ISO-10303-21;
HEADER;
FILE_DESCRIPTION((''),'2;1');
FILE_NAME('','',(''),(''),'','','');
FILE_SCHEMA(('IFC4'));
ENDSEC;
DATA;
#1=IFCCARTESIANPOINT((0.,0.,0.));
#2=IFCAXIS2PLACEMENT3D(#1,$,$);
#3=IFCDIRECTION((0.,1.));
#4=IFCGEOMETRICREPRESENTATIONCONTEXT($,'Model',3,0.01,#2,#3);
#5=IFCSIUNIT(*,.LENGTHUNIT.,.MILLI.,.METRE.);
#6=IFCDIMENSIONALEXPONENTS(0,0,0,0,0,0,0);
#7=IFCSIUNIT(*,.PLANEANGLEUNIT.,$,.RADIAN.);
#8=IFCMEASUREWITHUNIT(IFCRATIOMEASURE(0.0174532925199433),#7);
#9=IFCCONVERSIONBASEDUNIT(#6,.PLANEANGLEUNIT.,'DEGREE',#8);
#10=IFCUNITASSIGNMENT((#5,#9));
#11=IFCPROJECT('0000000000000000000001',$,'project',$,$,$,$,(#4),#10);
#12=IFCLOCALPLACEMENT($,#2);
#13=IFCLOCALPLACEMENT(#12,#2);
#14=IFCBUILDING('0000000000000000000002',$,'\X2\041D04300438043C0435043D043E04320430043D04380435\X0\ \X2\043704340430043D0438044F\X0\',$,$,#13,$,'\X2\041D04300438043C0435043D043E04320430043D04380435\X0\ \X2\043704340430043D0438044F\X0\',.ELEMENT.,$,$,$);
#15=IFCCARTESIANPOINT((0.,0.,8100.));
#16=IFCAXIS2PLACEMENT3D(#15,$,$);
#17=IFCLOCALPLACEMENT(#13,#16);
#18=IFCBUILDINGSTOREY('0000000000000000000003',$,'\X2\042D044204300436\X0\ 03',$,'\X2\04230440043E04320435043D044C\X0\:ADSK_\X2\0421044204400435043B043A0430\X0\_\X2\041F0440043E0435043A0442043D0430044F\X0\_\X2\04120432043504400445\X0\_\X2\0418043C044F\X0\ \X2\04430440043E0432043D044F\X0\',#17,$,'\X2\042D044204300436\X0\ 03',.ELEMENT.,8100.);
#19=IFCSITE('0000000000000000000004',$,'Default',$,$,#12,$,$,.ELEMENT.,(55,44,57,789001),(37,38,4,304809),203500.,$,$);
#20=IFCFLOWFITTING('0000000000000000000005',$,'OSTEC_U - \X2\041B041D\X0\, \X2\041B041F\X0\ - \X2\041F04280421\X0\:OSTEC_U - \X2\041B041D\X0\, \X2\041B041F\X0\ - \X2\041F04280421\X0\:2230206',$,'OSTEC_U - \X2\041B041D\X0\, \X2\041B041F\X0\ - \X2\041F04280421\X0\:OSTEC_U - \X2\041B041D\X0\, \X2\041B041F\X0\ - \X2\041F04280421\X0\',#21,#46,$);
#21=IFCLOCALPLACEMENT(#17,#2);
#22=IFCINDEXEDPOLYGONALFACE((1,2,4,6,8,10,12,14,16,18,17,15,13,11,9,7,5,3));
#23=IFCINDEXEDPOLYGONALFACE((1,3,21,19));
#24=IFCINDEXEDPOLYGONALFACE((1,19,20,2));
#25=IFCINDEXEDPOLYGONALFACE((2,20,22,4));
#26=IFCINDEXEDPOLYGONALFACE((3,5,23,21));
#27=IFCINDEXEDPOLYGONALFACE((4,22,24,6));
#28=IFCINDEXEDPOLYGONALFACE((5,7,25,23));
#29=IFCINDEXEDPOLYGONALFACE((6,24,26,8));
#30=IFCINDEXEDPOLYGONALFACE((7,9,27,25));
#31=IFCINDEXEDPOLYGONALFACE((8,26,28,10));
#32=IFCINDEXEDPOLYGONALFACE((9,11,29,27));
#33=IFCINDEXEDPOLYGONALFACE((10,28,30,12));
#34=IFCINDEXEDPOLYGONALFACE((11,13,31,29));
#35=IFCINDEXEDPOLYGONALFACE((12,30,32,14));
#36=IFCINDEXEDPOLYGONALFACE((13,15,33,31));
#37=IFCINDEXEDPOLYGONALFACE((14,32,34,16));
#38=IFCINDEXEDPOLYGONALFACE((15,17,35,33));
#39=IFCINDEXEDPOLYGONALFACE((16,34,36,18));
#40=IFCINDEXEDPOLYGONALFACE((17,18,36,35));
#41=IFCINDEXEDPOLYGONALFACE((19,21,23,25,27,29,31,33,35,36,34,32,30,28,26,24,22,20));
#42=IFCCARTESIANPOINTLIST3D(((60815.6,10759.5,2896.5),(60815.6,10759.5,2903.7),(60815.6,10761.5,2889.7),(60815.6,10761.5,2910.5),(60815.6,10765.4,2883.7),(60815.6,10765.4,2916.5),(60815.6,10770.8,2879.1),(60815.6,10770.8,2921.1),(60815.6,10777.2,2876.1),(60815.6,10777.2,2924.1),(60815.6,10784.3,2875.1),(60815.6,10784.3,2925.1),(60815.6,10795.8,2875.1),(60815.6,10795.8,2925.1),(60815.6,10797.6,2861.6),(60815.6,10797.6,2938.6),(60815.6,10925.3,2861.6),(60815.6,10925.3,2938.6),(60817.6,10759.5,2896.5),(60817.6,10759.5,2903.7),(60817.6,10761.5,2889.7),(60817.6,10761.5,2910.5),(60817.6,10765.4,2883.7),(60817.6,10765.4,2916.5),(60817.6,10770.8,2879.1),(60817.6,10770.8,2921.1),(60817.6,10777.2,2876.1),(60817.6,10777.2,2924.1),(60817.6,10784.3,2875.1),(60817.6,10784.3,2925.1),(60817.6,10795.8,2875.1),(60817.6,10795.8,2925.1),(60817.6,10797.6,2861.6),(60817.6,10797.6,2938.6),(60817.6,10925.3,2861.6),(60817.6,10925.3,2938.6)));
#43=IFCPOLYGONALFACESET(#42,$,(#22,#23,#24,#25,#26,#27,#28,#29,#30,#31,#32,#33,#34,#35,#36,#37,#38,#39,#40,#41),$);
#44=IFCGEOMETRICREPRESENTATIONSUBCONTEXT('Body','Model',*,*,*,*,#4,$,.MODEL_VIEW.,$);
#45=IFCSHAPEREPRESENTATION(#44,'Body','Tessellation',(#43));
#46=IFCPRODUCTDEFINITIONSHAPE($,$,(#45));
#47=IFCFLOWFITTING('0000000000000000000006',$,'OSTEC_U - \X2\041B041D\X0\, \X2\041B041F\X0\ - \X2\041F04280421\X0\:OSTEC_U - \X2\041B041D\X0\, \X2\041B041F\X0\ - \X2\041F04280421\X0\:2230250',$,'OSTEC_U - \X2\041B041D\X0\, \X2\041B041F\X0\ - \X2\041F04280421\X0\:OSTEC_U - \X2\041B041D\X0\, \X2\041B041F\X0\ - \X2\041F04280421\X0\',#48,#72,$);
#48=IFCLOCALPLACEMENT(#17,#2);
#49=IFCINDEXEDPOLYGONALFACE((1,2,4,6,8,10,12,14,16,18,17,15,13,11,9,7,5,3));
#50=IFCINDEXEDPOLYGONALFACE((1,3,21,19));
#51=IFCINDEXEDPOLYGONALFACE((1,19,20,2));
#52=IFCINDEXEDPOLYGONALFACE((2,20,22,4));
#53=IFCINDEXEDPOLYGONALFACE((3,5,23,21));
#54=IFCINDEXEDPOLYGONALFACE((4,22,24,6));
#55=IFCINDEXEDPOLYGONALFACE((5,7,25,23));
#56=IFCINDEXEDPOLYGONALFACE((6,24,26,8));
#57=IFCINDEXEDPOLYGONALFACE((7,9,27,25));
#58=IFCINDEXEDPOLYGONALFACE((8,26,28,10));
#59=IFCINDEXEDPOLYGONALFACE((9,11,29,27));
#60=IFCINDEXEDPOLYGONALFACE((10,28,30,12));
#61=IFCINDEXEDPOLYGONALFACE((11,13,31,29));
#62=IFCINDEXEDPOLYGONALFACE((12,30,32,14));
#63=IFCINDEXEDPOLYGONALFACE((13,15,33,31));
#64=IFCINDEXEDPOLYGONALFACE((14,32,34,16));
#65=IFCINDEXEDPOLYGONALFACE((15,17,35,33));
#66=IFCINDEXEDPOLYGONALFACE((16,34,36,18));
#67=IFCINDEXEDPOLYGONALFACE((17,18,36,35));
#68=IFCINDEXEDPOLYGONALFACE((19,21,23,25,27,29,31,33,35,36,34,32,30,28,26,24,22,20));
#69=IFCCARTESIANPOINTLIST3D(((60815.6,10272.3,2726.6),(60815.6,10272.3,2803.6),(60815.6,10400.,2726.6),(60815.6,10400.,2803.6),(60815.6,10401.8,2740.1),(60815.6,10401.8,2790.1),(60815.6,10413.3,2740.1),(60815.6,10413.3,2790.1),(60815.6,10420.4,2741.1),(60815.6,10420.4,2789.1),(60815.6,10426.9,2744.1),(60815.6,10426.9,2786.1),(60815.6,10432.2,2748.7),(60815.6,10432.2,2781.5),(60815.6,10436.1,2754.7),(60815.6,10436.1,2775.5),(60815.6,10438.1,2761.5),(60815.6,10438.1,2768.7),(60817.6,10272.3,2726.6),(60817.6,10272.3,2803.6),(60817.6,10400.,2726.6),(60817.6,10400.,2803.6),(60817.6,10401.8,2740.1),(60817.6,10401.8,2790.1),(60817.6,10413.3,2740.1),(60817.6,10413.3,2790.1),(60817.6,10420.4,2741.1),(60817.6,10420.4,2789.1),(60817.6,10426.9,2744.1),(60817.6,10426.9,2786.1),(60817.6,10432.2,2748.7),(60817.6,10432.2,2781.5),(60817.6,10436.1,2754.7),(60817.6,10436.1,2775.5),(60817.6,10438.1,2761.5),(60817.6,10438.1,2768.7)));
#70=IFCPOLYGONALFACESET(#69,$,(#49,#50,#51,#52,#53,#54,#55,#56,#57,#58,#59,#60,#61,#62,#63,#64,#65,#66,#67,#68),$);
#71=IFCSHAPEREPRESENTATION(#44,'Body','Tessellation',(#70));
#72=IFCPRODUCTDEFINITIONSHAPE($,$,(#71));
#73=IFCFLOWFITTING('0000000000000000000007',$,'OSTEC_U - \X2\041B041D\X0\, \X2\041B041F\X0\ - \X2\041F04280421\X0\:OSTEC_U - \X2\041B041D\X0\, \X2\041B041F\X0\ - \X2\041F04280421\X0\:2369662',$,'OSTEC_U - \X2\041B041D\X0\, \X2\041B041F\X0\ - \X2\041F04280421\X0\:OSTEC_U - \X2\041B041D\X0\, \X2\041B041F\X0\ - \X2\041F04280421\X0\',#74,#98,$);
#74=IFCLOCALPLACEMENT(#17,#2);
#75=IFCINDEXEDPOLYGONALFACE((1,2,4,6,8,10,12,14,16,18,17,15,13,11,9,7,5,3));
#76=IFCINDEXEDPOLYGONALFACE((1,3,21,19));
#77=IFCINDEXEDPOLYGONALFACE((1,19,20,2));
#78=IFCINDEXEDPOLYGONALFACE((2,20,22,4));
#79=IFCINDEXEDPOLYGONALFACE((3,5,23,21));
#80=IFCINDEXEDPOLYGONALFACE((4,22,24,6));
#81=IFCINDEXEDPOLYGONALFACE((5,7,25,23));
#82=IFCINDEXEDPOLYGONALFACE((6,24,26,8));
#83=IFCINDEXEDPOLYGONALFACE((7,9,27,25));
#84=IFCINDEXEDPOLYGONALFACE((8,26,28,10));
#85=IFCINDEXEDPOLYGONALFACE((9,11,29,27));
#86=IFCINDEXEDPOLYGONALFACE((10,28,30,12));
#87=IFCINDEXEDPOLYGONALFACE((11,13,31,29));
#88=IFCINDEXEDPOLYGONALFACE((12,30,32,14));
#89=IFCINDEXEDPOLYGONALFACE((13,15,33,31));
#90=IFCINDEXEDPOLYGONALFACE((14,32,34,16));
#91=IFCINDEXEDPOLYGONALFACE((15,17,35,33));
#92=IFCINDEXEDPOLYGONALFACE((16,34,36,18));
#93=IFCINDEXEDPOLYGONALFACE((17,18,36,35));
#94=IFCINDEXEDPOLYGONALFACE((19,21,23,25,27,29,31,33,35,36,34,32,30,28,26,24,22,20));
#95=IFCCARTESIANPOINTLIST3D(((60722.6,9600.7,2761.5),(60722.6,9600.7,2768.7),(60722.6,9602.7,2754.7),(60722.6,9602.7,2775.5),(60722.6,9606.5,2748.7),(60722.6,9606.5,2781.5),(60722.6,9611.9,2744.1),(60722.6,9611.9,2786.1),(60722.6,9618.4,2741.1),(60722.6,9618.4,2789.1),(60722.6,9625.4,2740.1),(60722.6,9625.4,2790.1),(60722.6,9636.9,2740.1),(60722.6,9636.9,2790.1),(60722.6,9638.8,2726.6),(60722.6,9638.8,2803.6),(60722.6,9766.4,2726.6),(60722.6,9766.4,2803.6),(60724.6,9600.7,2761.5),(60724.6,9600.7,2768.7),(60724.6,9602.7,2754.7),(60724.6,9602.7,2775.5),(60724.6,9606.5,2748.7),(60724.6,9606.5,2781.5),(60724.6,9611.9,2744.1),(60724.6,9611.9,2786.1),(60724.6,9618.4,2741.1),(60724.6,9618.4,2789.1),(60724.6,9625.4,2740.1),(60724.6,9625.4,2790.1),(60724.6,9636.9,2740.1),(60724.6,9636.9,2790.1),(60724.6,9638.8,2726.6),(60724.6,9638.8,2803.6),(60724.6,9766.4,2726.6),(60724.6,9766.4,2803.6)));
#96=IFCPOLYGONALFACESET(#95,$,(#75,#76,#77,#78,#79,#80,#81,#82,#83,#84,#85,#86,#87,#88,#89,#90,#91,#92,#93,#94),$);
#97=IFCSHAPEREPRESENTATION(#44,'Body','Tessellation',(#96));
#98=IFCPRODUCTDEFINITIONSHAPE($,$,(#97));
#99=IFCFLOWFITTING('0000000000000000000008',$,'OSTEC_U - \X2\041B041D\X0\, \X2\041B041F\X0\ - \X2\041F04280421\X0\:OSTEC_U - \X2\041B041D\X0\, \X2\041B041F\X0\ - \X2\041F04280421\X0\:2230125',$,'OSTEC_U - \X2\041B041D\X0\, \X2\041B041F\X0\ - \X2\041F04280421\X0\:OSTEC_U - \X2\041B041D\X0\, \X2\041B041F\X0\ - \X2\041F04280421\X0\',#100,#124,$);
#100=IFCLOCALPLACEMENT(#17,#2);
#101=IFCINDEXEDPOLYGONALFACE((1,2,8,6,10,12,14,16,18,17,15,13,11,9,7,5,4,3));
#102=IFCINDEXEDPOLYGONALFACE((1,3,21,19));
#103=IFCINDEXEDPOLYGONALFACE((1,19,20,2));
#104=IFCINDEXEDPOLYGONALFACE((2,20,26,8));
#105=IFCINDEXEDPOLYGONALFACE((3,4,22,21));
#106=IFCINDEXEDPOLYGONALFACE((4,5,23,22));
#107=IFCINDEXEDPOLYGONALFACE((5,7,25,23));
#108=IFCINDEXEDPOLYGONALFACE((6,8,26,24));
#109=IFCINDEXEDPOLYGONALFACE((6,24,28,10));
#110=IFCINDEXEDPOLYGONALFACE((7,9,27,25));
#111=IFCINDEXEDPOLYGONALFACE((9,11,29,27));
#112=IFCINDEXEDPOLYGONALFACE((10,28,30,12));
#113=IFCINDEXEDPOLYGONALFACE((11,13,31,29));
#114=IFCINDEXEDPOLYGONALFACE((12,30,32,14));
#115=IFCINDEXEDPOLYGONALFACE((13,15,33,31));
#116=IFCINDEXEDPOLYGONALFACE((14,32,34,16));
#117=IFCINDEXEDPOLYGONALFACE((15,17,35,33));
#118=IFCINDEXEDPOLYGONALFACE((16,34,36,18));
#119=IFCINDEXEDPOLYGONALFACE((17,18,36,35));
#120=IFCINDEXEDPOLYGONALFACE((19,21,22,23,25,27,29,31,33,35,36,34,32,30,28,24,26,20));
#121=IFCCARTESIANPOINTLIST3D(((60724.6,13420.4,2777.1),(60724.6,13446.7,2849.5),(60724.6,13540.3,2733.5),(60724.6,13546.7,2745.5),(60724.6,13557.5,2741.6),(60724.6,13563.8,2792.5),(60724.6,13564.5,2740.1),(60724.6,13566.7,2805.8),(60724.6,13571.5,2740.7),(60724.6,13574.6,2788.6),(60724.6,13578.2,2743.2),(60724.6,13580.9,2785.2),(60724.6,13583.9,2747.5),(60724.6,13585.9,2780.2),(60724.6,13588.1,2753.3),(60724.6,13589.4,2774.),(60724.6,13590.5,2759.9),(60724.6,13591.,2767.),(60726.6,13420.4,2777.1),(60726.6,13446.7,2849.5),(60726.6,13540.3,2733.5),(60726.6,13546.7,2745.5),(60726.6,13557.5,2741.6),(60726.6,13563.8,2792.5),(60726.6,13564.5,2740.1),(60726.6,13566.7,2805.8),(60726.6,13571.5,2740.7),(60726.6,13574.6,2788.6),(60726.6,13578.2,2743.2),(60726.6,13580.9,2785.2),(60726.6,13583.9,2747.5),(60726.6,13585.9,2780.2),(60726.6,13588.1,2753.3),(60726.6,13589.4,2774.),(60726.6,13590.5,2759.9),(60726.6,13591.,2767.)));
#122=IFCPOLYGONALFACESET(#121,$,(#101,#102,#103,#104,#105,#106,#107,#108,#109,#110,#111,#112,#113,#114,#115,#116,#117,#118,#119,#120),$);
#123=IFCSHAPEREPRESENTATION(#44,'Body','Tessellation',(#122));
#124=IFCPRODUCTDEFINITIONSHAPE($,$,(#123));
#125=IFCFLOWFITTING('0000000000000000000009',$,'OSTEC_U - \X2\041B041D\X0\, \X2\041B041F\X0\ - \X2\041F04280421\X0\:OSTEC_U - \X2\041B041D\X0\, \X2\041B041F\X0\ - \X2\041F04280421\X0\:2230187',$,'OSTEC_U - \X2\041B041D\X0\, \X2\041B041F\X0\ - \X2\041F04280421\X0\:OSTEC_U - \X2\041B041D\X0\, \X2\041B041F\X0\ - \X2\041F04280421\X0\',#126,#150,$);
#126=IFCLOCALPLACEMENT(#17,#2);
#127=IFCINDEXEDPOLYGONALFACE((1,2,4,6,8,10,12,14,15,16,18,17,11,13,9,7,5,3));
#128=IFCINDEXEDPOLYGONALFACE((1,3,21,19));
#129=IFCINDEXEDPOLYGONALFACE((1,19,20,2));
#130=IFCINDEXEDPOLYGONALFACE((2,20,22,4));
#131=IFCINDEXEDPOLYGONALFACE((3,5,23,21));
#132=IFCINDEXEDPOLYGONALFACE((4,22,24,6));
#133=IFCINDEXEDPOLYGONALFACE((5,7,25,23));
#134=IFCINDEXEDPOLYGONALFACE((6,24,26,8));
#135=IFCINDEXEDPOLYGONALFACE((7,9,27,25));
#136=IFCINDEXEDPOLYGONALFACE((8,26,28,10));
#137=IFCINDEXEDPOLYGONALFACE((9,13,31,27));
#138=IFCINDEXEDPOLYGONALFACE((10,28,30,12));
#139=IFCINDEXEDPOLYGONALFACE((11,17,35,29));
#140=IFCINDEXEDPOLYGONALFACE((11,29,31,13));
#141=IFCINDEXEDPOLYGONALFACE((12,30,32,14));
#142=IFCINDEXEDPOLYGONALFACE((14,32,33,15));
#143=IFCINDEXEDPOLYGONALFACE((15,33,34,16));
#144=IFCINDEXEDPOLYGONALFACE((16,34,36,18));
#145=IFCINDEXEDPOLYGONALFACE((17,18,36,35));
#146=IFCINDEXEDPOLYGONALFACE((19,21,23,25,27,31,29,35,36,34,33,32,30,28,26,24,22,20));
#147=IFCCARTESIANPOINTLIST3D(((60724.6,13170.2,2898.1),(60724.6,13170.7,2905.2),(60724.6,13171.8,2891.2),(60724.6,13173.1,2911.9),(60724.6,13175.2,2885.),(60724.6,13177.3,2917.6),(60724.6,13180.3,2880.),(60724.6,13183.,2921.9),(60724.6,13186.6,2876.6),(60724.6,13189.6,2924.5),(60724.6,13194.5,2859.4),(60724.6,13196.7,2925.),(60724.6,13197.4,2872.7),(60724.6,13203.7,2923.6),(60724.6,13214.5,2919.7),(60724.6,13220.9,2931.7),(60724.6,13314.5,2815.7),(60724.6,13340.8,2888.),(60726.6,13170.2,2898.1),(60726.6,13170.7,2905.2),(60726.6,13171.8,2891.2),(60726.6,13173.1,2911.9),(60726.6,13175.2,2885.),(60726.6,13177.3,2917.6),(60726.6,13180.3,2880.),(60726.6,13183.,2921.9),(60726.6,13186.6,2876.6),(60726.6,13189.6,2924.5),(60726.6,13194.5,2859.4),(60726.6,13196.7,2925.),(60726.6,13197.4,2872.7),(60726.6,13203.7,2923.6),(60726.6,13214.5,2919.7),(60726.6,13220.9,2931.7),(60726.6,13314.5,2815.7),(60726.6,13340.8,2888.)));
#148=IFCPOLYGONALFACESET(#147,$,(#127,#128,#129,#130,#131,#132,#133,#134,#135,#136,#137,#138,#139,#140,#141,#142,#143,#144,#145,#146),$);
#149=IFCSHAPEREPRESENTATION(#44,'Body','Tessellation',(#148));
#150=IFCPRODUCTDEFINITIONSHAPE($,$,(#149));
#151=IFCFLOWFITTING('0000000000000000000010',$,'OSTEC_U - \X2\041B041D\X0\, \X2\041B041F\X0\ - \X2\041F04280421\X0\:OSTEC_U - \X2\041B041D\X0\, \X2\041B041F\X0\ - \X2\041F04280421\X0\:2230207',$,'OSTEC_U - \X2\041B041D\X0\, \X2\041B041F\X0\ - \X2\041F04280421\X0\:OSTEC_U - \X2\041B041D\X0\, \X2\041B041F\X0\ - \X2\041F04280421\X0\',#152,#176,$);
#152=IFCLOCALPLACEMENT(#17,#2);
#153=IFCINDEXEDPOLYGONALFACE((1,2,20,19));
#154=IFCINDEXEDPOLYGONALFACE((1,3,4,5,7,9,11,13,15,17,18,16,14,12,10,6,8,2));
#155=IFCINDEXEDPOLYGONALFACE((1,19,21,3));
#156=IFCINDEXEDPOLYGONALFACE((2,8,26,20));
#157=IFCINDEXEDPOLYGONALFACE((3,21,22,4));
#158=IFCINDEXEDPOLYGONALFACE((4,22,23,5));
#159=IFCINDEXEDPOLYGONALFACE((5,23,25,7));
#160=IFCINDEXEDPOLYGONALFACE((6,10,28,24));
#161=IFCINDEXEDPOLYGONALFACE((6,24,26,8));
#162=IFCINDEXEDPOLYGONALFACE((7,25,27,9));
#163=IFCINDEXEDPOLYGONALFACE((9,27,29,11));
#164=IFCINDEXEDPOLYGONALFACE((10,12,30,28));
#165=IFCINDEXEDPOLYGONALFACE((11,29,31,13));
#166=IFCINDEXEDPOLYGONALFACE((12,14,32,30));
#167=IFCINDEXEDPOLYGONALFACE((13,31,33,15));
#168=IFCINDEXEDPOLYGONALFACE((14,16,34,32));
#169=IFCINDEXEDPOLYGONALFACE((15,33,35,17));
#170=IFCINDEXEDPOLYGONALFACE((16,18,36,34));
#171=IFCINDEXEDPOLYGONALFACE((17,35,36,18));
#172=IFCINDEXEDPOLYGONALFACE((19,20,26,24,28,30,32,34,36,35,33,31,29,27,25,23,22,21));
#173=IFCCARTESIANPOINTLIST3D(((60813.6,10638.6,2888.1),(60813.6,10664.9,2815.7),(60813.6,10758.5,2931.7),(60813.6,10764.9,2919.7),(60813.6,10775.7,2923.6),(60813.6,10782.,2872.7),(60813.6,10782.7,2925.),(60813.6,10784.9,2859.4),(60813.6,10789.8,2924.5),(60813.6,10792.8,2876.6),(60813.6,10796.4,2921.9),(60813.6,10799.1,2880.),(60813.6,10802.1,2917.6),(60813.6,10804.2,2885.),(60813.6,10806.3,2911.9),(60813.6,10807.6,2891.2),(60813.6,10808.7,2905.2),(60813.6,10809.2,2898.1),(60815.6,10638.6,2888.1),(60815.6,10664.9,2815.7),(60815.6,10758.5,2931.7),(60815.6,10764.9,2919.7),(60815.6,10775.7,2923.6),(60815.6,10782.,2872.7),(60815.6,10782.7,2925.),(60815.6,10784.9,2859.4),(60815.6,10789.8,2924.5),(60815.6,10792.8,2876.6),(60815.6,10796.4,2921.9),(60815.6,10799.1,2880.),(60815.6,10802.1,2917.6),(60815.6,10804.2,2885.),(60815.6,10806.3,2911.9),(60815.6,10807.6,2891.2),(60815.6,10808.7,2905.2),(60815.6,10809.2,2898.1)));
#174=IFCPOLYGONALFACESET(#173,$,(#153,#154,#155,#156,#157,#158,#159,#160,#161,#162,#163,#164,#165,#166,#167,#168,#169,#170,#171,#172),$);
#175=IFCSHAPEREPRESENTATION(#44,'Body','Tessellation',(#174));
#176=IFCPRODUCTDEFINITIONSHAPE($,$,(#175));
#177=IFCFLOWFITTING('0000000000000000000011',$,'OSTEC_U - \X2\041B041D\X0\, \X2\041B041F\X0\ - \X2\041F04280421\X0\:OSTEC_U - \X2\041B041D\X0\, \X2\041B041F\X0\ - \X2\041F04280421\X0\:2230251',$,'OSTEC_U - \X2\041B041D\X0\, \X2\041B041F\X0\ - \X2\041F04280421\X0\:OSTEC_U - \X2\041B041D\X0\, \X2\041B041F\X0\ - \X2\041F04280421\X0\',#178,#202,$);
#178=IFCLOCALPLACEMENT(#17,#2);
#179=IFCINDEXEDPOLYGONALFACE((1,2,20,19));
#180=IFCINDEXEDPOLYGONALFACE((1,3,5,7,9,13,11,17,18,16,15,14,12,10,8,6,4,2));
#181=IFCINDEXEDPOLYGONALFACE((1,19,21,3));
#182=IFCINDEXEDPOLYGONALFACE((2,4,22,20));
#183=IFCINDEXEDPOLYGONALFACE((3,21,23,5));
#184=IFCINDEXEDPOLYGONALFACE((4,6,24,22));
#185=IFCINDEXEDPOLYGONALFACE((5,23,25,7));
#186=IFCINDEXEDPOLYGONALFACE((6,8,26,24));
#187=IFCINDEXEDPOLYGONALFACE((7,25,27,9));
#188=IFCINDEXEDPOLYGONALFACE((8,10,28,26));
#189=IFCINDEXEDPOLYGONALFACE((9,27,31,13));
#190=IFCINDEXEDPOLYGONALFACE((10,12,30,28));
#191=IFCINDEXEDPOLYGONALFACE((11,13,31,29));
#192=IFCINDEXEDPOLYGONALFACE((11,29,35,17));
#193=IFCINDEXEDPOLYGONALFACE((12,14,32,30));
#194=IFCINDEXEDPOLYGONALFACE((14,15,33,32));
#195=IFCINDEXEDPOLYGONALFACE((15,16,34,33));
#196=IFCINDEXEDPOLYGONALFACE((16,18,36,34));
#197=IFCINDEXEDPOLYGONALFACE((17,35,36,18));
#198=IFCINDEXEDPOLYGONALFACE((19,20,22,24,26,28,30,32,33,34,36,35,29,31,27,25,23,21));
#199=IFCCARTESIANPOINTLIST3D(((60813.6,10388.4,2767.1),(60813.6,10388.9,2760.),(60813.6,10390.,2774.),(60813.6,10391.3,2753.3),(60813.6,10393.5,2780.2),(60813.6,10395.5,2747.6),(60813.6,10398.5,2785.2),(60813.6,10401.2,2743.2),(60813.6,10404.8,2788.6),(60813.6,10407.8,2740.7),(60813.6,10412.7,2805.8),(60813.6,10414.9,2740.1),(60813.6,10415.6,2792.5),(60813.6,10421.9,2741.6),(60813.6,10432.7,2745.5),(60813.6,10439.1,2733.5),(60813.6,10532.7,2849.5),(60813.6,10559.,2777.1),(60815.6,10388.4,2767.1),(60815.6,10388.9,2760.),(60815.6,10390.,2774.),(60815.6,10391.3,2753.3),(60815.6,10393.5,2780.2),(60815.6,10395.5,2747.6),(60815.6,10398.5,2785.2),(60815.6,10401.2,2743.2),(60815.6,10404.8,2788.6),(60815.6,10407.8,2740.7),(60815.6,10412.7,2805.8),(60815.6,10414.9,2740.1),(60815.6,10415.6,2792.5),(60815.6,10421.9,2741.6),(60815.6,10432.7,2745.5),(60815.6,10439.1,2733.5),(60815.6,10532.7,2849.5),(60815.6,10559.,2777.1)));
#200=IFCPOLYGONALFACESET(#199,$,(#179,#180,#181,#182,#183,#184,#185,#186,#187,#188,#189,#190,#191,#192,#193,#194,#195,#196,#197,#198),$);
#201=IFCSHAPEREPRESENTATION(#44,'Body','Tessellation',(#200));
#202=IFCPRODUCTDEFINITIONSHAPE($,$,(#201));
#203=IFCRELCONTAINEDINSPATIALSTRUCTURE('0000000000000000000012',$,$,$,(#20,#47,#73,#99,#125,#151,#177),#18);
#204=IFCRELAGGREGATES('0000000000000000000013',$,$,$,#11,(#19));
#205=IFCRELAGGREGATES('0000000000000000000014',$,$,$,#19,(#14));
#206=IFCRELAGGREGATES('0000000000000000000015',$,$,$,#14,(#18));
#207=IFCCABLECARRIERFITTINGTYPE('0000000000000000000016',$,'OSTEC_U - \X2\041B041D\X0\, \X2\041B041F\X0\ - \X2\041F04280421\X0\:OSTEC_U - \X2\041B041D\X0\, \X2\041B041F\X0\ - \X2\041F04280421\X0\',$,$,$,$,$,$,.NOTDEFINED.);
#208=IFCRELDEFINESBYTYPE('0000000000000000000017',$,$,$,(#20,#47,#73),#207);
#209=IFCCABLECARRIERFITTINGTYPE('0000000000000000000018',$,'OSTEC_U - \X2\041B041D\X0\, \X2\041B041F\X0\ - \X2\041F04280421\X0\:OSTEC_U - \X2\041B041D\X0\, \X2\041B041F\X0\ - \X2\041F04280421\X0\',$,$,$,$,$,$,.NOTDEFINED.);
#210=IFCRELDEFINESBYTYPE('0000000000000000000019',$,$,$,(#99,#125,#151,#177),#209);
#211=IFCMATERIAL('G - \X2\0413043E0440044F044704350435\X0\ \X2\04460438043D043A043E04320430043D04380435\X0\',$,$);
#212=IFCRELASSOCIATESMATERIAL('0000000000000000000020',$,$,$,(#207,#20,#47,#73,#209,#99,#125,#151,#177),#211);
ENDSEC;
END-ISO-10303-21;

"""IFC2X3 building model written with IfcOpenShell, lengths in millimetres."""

from ifc_helpers import new_model, entity, si_unit, converted_unit, direction, frame, frame_2d, origin, place, context, subcontext, project, spatial, polyline, circle_curve, parameter, trimmed, segment, composite_curve, outline, extrude, source, transform, mapped, material, type_object, type_shapes, element, save


model = new_model("IFC2X3")

# Units and contexts
model_context = context("Model", 3, precision=0.01, world=origin(), true_north=direction((0.0, 1.0)))
body_context = subcontext(model_context, "Body", "Model", "MODEL_VIEW")
ifc_project = project(units=[si_unit("LENGTHUNIT", "METRE", prefix="MILLI"), converted_unit("PLANEANGLEUNIT", "DEGREE", entity("IfcRatioMeasure", 0.0174532925199433), si_unit("PLANEANGLEUNIT", "RADIAN"), dimensions=[0, 0, 0, 0, 0, 0, 0])], contexts=[model_context])

# Site, building, storey
site_placement = place(None, frame((0.0, 0.0, 0.0)))
site = spatial("IfcSite", under=ifc_project, at=site_placement, Name="Default", CompositionType="ELEMENT", RefLatitude=(55, 44, 57, 789001), RefLongitude=(37, 38, 4, 304809), RefElevation=203500.0)
building_placement = place(site_placement, origin())
building = spatial("IfcBuilding", under=site, at=building_placement, Name="Наименование здания", LongName="Наименование здания", CompositionType="ELEMENT")
storey_placement = place(building_placement, frame((0.0, 0.0, 8100.0)))
storey = spatial("IfcBuildingStorey", under=building, at=storey_placement, Name="Этаж 03", ObjectType="Уровень:ADSK_Стрелка_Проектная_Вверх_Имя уровня", LongName="Этаж 03", CompositionType="ELEMENT", Elevation=8100.0)

# Flow fittings
ifc_material_1 = material(Name="G - Горячее цинкование")
cable_carrier_fitting_type_1 = type_object("IfcCableCarrierFittingType", Name="OSTEC_U - ЛН, ЛП - ПШС:OSTEC_U - ЛН, ЛП - ПШС", PredefinedType="NOTDEFINED", material=ifc_material_1)
shared_shape_1 = source(origin(), body_context, "Body", "SweptSolid", [
    extrude(outline(composite_curve([segment(trimmed(circle_curve(frame_2d((-41.5, 0.0), x_axis=(1.0, 0.0)), 25.0), [parameter(90.0)], [parameter(270.0)], True, "PARAMETER"), True, "CONTINUOUS"), segment(polyline([(-41.5, -25.0), (-30.0, -25.0)]), True, "CONTINUOUS"), segment(polyline([(-30.0, -25.0), (-28.1, -38.5)]), True, "CONTINUOUS"), segment(polyline([(-28.1, -38.5), (99.5, -38.5)]), True, "CONTINUOUS"), segment(polyline([(99.5, -38.5), (99.5, 38.5)]), True, "CONTINUOUS"), segment(polyline([(99.5, 38.5), (-28.1, 38.5)]), True, "CONTINUOUS"), segment(polyline([(-28.1, 38.5), (-30.0, 25.0)]), True, "CONTINUOUS"), segment(polyline([(-30.0, 25.0), (-41.5, 25.0)]), True, "CONTINUOUS")], self_intersect=False)), frame((41.5, 0.0, 0.0)), (0.0, 0.0, 1.0), 2.0),
])
type_shapes(cable_carrier_fitting_type_1, [shared_shape_1])
for number, where, z_axis, x_axis, name in (
    (1, (60815.6, 10784.3, 2900.1), (1.0, 0.0, 0.0), (0.0, 1.0, 0.0), "OSTEC_U - ЛН, ЛП - ПШС:OSTEC_U - ЛН, ЛП - ПШС:2230206"),
    (2, (60815.6, 10413.3, 2765.1), (1.0, 0.0, 0.0), (0.0, -1.0, 0.000005), "OSTEC_U - ЛН, ЛП - ПШС:OSTEC_U - ЛН, ЛП - ПШС:2230250"),
    (3, (60724.6, 9625.4, 2765.1), (-1.0, 0.0, 0.0), (0.0, 1.0, -0.000005), "OSTEC_U - ЛН, ЛП - ПШС:OSTEC_U - ЛН, ЛП - ПШС:2369662"),
):
    element("IfcFlowFitting", number, at=place(storey_placement, frame(where, z_axis=z_axis, x_axis=x_axis)), inside=storey, type_object=cable_carrier_fitting_type_1, material=ifc_material_1, Name=name, ObjectType="OSTEC_U - ЛН, ЛП - ПШС:OSTEC_U - ЛН, ЛП - ПШС", context=body_context, shape_type="MappedRepresentation", body=[
        mapped(shared_shape_1, transform((0.0, 0.0, 0.0), scale=1.0)),
    ])
cable_carrier_fitting_type_2 = type_object("IfcCableCarrierFittingType", Name="OSTEC_U - ЛН, ЛП - ПШС:OSTEC_U - ЛН, ЛП - ПШС", PredefinedType="NOTDEFINED", material=ifc_material_1)
shared_shape_2 = source(origin(), body_context, "Body", "SweptSolid", [
    extrude(outline(composite_curve([segment(trimmed(circle_curve(frame_2d((-41.5, 0.0), x_axis=(1.0, 0.0)), 25.0), [parameter(90.0)], [parameter(270.0)], True, "PARAMETER"), True, "CONTINUOUS"), segment(polyline([(-41.5, -25.0), (-30.0, -25.0)]), True, "CONTINUOUS"), segment(polyline([(-30.0, -25.0), (-28.1, -38.5)]), True, "CONTINUOUS"), segment(polyline([(-28.1, -38.5), (99.5, -38.5)]), True, "CONTINUOUS"), segment(polyline([(99.5, -38.5), (99.5, 38.5)]), True, "CONTINUOUS"), segment(polyline([(99.5, 38.5), (-28.1, 38.5)]), True, "CONTINUOUS"), segment(polyline([(-28.1, 38.5), (-30.0, 25.0)]), True, "CONTINUOUS"), segment(polyline([(-30.0, 25.0), (-41.5, 25.0)]), True, "CONTINUOUS")], self_intersect=False)), frame((41.5, 0.0, 0.0), z_axis=(0.0, 0.0, -1.0), x_axis=(1.0, 0.0, 0.0)), (0.0, 0.0, -1.0), 2.0),
])
type_shapes(cable_carrier_fitting_type_2, [shared_shape_2])
for number, where, z_axis, x_axis, name in (
    (4, (60726.6, 13566.0, 2765.1), (-1.0, 0.0, 0.0), (0.0, -0.939662, 0.342104), "OSTEC_U - ЛН, ЛП - ПШС:OSTEC_U - ЛН, ЛП - ПШС:2230125"),
    (5, (60726.6, 13195.1, 2900.1), (-1.0, 0.0, 0.0), (0.0, 0.939662, -0.342104), "OSTEC_U - ЛН, ЛП - ПШС:OSTEC_U - ЛН, ЛП - ПШС:2230187"),
    (6, (60813.6, 10784.3, 2900.1), (1.0, 0.0, 0.0), (0.0, -0.939693, -0.34202), "OSTEC_U - ЛН, ЛП - ПШС:OSTEC_U - ЛН, ЛП - ПШС:2230207"),
    (7, (60813.6, 10413.3, 2765.1), (1.0, 0.0, 0.0), (0.0, 0.939693, 0.34202), "OSTEC_U - ЛН, ЛП - ПШС:OSTEC_U - ЛН, ЛП - ПШС:2230251"),
):
    element("IfcFlowFitting", number, at=place(storey_placement, frame(where, z_axis=z_axis, x_axis=x_axis)), inside=storey, type_object=cable_carrier_fitting_type_2, material=ifc_material_1, Name=name, ObjectType="OSTEC_U - ЛН, ЛП - ПШС:OSTEC_U - ЛН, ЛП - ПШС", context=body_context, shape_type="MappedRepresentation", body=[
        mapped(shared_shape_2, transform((0.0, 0.0, 0.0), scale=1.0)),
    ])

save(model, "model.ifc")
